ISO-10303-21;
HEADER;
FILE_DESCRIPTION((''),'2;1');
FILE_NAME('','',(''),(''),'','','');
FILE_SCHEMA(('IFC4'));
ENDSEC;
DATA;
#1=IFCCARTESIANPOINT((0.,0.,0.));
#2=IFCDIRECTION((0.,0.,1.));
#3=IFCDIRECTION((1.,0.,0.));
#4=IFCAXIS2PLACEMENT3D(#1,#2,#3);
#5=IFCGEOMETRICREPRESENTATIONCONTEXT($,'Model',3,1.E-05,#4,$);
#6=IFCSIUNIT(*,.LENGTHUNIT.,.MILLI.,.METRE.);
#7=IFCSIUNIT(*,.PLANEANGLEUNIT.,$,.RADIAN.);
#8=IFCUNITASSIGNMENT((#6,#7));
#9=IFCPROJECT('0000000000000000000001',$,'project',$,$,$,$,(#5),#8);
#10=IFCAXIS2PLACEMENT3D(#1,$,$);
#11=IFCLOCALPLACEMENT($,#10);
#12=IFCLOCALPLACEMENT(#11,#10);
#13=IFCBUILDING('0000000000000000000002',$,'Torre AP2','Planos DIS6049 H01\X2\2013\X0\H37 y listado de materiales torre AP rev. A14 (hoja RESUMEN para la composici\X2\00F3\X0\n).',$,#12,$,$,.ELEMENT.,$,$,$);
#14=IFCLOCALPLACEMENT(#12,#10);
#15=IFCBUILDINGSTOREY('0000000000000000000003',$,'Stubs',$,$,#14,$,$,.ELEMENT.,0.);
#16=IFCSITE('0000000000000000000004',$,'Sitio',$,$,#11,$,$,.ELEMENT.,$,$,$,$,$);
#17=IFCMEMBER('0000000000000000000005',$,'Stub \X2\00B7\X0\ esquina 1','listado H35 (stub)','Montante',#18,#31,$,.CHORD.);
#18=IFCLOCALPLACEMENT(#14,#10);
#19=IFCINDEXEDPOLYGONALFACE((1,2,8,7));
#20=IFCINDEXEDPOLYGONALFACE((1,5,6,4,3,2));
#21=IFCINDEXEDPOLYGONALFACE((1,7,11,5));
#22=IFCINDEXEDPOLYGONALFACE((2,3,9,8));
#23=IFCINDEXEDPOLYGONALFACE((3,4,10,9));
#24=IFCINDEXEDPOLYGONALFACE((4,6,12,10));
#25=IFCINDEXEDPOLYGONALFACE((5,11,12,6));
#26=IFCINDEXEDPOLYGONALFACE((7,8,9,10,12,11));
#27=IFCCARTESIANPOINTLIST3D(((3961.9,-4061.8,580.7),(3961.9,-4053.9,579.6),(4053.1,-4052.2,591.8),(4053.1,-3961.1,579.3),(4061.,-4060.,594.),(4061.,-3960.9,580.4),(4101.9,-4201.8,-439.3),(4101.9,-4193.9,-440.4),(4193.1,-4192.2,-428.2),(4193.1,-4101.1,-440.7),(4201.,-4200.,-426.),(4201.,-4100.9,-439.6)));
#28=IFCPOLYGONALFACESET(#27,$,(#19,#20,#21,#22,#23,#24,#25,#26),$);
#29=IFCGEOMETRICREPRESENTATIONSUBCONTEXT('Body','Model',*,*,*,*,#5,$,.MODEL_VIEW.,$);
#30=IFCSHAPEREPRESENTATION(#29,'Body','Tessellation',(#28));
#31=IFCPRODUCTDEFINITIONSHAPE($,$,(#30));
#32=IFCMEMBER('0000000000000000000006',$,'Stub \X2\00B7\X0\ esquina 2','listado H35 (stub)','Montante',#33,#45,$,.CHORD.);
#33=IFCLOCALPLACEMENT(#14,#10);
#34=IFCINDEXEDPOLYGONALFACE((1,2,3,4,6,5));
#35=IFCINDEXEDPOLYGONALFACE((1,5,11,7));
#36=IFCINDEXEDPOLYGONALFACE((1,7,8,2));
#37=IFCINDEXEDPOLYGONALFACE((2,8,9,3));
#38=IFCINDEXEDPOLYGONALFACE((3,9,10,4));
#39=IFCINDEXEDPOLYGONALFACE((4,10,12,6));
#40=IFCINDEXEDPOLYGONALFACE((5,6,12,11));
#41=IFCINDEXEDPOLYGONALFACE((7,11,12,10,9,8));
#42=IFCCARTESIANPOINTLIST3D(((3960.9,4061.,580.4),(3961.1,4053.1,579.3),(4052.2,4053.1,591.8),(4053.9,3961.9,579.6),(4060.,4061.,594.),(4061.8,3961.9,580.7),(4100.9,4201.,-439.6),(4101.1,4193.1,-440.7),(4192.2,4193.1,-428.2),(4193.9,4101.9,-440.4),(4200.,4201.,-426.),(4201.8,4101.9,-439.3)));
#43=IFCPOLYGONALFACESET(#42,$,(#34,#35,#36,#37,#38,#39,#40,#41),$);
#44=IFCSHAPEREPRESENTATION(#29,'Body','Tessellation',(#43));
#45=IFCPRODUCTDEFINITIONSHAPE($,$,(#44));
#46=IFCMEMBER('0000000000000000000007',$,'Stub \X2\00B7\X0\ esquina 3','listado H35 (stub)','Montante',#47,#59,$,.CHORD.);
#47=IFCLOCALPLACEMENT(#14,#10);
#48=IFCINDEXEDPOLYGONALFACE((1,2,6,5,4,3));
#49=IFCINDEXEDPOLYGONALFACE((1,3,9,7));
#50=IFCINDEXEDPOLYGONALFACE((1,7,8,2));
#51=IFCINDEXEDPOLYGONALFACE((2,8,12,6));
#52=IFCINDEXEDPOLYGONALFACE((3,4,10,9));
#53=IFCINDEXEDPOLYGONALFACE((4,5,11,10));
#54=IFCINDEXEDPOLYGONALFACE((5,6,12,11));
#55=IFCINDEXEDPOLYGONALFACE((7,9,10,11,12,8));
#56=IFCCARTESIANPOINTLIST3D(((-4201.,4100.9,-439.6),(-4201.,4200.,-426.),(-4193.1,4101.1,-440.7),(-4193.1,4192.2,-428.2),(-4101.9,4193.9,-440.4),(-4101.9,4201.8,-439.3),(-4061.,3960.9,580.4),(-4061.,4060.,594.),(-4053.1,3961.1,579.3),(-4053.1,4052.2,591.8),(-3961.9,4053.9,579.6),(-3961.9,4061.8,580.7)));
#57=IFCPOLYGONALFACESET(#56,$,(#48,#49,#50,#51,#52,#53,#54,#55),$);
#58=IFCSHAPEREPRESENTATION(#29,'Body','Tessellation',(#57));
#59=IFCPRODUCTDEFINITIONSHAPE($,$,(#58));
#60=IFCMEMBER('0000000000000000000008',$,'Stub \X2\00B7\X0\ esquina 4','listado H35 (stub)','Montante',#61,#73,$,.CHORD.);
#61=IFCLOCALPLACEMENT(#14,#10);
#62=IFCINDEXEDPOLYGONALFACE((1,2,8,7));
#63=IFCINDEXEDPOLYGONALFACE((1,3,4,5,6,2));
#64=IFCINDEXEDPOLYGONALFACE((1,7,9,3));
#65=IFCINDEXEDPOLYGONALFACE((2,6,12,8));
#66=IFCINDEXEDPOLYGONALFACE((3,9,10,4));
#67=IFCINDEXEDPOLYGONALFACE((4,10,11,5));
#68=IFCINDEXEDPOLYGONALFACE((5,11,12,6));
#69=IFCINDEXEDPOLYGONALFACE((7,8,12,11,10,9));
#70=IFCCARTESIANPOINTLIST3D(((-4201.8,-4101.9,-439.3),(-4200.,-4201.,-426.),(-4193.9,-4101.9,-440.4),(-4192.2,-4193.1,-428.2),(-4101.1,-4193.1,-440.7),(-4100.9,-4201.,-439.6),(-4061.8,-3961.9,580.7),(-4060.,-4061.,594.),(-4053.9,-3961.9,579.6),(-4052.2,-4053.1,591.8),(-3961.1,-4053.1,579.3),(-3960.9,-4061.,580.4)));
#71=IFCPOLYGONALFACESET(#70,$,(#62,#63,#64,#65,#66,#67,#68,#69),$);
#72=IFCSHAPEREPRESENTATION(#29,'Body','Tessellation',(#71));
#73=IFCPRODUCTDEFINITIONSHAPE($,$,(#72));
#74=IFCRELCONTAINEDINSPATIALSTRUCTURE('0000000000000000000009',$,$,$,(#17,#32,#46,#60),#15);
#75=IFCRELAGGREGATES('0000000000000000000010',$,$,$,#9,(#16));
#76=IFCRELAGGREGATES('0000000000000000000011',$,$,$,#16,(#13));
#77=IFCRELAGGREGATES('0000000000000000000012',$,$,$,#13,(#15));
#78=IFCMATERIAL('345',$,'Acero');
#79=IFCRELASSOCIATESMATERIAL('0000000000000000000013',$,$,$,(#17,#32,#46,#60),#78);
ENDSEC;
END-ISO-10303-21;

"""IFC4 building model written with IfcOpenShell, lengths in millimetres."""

from ifc_helpers import new_model, si_unit, frame, frame_2d, origin, origin_with_axes, place, context, subcontext, project, spatial, l_section, extrude, material, element, save


model = new_model("IFC4")

# Units and contexts
model_context = context("Model", 3, precision=1e-05, world=origin_with_axes())
body_context = subcontext(model_context, "Body", "Model", "MODEL_VIEW")
ifc_project = project(units=[si_unit("LENGTHUNIT", "METRE", prefix="MILLI"), si_unit("PLANEANGLEUNIT", "RADIAN")], contexts=[model_context])

# Site, building, storey
site_placement = place(None, origin())
site = spatial("IfcSite", under=ifc_project, at=site_placement, Name="Sitio", CompositionType="ELEMENT")
building_placement = place(site_placement, origin())
building = spatial("IfcBuilding", under=site, at=building_placement, Name="Torre AP2", Description="Planos DIS6049 H01–H37 y listado de materiales torre AP rev. A14 (hoja RESUMEN para la composición).", CompositionType="ELEMENT")
storey_placement = place(building_placement, origin())
storey = spatial("IfcBuildingStorey", under=building, at=storey_placement, Name="Stubs", CompositionType="ELEMENT", Elevation=0.0)

# Members
ifc_material = material(Name="345", Category="Acero")
for number, where, z_axis, x_axis, name in (
    (1, (4061.0, -4060.0, 594.0), (0.13474, -0.13474, -0.981677), (-0.990881, -0.018322, -0.133488), "Stub · esquina 1"),
    (2, (4060.0, 4061.0, 594.0), (0.13474, 0.13474, -0.981677), (0.018322, -0.990881, -0.133488), "Stub · esquina 2"),
    (3, (-4061.0, 4060.0, 594.0), (-0.13474, 0.13474, -0.981677), (0.990881, 0.018322, -0.133488), "Stub · esquina 3"),
    (4, (-4060.0, -4061.0, 594.0), (-0.13474, -0.13474, -0.981677), (-0.018322, 0.990881, -0.133488), "Stub · esquina 4"),
):
    element("IfcMember", number, at=place(storey_placement, frame(where, z_axis=z_axis, x_axis=x_axis)), inside=storey, material=ifc_material, Name=name, Description="listado H35 (stub)", ObjectType="Montante", PredefinedType="CHORD", context=body_context, shape_type="SweptSolid", body=[
        extrude(l_section(Depth=100.0, Width=100.0, Thickness=8.0, at=frame_2d((50.0, 50.0))), None, (0.0, 0.0, 1.0), 1039.0),
    ])

save(model, "model.ifc")
